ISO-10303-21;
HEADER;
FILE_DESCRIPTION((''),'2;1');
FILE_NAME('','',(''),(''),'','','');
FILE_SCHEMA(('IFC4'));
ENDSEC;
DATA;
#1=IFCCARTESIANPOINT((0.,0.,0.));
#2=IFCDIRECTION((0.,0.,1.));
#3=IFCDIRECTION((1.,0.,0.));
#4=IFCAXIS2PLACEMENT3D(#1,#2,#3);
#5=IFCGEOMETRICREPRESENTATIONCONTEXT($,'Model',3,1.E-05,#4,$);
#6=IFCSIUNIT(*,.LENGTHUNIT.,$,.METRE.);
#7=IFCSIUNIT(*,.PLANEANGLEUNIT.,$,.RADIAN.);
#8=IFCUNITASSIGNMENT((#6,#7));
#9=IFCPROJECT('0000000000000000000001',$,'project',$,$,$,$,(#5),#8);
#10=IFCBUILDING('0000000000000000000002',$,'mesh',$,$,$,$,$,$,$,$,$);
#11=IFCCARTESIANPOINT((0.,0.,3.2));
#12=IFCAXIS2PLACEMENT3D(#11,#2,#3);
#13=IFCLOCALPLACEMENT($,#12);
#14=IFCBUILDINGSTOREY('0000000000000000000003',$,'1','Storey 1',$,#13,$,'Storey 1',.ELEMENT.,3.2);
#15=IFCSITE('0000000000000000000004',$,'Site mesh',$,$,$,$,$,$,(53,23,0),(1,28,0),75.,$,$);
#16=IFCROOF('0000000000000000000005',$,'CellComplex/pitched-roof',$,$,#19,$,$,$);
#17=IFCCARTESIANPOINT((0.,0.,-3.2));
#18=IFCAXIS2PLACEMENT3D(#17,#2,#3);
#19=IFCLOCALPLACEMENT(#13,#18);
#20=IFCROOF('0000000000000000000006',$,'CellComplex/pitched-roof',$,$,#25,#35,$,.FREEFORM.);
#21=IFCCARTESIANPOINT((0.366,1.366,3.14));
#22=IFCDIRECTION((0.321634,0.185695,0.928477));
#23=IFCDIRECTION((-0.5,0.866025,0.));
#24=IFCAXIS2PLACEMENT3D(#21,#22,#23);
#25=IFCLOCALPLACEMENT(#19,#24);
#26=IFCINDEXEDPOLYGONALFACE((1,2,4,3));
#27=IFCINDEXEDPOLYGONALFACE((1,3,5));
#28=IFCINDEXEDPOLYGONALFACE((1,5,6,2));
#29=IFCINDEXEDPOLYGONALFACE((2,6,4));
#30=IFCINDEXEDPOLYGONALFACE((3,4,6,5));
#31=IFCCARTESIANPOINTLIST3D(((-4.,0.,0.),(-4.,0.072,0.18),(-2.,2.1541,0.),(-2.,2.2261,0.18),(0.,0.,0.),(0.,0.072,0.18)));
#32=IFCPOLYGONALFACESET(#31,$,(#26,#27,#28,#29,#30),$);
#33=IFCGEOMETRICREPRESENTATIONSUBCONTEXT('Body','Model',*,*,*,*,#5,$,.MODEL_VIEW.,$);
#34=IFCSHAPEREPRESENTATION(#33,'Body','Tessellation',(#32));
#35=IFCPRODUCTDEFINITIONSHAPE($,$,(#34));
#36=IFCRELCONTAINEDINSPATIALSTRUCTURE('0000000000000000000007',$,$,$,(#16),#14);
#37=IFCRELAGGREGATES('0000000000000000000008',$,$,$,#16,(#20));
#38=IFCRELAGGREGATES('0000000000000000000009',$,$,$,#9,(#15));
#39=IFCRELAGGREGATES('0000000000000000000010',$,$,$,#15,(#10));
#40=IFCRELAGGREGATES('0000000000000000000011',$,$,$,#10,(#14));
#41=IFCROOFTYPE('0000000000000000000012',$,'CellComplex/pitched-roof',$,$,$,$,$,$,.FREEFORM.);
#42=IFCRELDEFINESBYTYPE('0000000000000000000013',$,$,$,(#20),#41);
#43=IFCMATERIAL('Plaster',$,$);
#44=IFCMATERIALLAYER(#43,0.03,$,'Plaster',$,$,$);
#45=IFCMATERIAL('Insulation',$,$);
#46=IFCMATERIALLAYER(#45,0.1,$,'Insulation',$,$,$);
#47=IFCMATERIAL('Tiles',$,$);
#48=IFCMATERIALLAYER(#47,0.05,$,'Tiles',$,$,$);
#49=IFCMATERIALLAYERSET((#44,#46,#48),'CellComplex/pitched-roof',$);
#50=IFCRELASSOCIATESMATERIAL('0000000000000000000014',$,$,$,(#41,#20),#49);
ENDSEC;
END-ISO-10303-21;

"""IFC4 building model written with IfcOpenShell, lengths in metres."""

from ifc_helpers import new_model, si_unit, frame, origin, origin_with_axes, place, context, subcontext, project, spatial, polyline, outline, extrude, material, layer, layer_set, layer_usage, type_object, element, aggregate, save


model = new_model("IFC4")

# Units and contexts
model_context = context("Model", 3, precision=1e-05, world=origin_with_axes())
body_context = subcontext(model_context, "Body", "Model", "MODEL_VIEW")
ifc_project = project(units=[si_unit("LENGTHUNIT", "METRE"), si_unit("PLANEANGLEUNIT", "RADIAN")], contexts=[model_context])

# Site, building, storey
site = spatial("IfcSite", under=ifc_project, Name="Site mesh", RefLatitude=(53, 23, 0), RefLongitude=(1, 28, 0), RefElevation=75.0)
building = spatial("IfcBuilding", under=site, Name="mesh")
storey_placement = place(None, frame((0.0, 0.0, 3.2), z_axis=(0.0, 0.0, 1.0), x_axis=(1.0, 0.0, 0.0)))
storey = spatial("IfcBuildingStorey", under=building, at=storey_placement, Name="1", Description="Storey 1", LongName="Storey 1", CompositionType="ELEMENT", Elevation=3.2)

# Shared definitions
ifc_material_1 = material(Name="Plaster")

# Roofs
roof_1_placement = place(storey_placement, frame((0.0, 0.0, -3.2), z_axis=(0.0, 0.0, 1.0), x_axis=(1.0, 0.0, 0.0)))
roof_1 = element("IfcRoof", 1, at=roof_1_placement, inside=storey, Name="CellComplex/pitched-roof")
ifc_layer_1 = layer(ifc_material_1, 0.03, Name="Plaster")
ifc_material_2 = material(Name="Insulation")
ifc_layer_2 = layer(ifc_material_2, 0.1, Name="Insulation")
ifc_material_3 = material(Name="Tiles")
ifc_layer_3 = layer(ifc_material_3, 0.05, Name="Tiles")
ifc_layer_set_1 = layer_set([ifc_layer_1, ifc_layer_2, ifc_layer_3], Name="CellComplex/pitched-roof")
ifc_layer_usage_1 = layer_usage(ifc_layer_set_1, "AXIS3", "POSITIVE", 0.0)
roof_type = type_object("IfcRoofType", Name="CellComplex/pitched-roof", PredefinedType="FREEFORM", material=ifc_layer_set_1)
roof_2_placement = place(roof_1_placement, frame((0.366, 1.366, 3.14), z_axis=(0.321634, 0.185695, 0.928477), x_axis=(-0.5, 0.866025, 0.0)))
roof_2 = element("IfcRoof", 2, at=roof_2_placement, type_object=roof_type, material=ifc_layer_usage_1, Name="CellComplex/pitched-roof", PredefinedType="FREEFORM", context=body_context, shape_type="SweptSolid", body=[
    extrude(outline(polyline([(0.0, 0.0), (-2.0, 2.1541), (-4.0, 0.0), (0.0, 0.0)])), origin(), (0.0, 0.371391, 0.928477), 0.1939),
])
aggregate(roof_1, [roof_2])

save(model, "model.ifc")
